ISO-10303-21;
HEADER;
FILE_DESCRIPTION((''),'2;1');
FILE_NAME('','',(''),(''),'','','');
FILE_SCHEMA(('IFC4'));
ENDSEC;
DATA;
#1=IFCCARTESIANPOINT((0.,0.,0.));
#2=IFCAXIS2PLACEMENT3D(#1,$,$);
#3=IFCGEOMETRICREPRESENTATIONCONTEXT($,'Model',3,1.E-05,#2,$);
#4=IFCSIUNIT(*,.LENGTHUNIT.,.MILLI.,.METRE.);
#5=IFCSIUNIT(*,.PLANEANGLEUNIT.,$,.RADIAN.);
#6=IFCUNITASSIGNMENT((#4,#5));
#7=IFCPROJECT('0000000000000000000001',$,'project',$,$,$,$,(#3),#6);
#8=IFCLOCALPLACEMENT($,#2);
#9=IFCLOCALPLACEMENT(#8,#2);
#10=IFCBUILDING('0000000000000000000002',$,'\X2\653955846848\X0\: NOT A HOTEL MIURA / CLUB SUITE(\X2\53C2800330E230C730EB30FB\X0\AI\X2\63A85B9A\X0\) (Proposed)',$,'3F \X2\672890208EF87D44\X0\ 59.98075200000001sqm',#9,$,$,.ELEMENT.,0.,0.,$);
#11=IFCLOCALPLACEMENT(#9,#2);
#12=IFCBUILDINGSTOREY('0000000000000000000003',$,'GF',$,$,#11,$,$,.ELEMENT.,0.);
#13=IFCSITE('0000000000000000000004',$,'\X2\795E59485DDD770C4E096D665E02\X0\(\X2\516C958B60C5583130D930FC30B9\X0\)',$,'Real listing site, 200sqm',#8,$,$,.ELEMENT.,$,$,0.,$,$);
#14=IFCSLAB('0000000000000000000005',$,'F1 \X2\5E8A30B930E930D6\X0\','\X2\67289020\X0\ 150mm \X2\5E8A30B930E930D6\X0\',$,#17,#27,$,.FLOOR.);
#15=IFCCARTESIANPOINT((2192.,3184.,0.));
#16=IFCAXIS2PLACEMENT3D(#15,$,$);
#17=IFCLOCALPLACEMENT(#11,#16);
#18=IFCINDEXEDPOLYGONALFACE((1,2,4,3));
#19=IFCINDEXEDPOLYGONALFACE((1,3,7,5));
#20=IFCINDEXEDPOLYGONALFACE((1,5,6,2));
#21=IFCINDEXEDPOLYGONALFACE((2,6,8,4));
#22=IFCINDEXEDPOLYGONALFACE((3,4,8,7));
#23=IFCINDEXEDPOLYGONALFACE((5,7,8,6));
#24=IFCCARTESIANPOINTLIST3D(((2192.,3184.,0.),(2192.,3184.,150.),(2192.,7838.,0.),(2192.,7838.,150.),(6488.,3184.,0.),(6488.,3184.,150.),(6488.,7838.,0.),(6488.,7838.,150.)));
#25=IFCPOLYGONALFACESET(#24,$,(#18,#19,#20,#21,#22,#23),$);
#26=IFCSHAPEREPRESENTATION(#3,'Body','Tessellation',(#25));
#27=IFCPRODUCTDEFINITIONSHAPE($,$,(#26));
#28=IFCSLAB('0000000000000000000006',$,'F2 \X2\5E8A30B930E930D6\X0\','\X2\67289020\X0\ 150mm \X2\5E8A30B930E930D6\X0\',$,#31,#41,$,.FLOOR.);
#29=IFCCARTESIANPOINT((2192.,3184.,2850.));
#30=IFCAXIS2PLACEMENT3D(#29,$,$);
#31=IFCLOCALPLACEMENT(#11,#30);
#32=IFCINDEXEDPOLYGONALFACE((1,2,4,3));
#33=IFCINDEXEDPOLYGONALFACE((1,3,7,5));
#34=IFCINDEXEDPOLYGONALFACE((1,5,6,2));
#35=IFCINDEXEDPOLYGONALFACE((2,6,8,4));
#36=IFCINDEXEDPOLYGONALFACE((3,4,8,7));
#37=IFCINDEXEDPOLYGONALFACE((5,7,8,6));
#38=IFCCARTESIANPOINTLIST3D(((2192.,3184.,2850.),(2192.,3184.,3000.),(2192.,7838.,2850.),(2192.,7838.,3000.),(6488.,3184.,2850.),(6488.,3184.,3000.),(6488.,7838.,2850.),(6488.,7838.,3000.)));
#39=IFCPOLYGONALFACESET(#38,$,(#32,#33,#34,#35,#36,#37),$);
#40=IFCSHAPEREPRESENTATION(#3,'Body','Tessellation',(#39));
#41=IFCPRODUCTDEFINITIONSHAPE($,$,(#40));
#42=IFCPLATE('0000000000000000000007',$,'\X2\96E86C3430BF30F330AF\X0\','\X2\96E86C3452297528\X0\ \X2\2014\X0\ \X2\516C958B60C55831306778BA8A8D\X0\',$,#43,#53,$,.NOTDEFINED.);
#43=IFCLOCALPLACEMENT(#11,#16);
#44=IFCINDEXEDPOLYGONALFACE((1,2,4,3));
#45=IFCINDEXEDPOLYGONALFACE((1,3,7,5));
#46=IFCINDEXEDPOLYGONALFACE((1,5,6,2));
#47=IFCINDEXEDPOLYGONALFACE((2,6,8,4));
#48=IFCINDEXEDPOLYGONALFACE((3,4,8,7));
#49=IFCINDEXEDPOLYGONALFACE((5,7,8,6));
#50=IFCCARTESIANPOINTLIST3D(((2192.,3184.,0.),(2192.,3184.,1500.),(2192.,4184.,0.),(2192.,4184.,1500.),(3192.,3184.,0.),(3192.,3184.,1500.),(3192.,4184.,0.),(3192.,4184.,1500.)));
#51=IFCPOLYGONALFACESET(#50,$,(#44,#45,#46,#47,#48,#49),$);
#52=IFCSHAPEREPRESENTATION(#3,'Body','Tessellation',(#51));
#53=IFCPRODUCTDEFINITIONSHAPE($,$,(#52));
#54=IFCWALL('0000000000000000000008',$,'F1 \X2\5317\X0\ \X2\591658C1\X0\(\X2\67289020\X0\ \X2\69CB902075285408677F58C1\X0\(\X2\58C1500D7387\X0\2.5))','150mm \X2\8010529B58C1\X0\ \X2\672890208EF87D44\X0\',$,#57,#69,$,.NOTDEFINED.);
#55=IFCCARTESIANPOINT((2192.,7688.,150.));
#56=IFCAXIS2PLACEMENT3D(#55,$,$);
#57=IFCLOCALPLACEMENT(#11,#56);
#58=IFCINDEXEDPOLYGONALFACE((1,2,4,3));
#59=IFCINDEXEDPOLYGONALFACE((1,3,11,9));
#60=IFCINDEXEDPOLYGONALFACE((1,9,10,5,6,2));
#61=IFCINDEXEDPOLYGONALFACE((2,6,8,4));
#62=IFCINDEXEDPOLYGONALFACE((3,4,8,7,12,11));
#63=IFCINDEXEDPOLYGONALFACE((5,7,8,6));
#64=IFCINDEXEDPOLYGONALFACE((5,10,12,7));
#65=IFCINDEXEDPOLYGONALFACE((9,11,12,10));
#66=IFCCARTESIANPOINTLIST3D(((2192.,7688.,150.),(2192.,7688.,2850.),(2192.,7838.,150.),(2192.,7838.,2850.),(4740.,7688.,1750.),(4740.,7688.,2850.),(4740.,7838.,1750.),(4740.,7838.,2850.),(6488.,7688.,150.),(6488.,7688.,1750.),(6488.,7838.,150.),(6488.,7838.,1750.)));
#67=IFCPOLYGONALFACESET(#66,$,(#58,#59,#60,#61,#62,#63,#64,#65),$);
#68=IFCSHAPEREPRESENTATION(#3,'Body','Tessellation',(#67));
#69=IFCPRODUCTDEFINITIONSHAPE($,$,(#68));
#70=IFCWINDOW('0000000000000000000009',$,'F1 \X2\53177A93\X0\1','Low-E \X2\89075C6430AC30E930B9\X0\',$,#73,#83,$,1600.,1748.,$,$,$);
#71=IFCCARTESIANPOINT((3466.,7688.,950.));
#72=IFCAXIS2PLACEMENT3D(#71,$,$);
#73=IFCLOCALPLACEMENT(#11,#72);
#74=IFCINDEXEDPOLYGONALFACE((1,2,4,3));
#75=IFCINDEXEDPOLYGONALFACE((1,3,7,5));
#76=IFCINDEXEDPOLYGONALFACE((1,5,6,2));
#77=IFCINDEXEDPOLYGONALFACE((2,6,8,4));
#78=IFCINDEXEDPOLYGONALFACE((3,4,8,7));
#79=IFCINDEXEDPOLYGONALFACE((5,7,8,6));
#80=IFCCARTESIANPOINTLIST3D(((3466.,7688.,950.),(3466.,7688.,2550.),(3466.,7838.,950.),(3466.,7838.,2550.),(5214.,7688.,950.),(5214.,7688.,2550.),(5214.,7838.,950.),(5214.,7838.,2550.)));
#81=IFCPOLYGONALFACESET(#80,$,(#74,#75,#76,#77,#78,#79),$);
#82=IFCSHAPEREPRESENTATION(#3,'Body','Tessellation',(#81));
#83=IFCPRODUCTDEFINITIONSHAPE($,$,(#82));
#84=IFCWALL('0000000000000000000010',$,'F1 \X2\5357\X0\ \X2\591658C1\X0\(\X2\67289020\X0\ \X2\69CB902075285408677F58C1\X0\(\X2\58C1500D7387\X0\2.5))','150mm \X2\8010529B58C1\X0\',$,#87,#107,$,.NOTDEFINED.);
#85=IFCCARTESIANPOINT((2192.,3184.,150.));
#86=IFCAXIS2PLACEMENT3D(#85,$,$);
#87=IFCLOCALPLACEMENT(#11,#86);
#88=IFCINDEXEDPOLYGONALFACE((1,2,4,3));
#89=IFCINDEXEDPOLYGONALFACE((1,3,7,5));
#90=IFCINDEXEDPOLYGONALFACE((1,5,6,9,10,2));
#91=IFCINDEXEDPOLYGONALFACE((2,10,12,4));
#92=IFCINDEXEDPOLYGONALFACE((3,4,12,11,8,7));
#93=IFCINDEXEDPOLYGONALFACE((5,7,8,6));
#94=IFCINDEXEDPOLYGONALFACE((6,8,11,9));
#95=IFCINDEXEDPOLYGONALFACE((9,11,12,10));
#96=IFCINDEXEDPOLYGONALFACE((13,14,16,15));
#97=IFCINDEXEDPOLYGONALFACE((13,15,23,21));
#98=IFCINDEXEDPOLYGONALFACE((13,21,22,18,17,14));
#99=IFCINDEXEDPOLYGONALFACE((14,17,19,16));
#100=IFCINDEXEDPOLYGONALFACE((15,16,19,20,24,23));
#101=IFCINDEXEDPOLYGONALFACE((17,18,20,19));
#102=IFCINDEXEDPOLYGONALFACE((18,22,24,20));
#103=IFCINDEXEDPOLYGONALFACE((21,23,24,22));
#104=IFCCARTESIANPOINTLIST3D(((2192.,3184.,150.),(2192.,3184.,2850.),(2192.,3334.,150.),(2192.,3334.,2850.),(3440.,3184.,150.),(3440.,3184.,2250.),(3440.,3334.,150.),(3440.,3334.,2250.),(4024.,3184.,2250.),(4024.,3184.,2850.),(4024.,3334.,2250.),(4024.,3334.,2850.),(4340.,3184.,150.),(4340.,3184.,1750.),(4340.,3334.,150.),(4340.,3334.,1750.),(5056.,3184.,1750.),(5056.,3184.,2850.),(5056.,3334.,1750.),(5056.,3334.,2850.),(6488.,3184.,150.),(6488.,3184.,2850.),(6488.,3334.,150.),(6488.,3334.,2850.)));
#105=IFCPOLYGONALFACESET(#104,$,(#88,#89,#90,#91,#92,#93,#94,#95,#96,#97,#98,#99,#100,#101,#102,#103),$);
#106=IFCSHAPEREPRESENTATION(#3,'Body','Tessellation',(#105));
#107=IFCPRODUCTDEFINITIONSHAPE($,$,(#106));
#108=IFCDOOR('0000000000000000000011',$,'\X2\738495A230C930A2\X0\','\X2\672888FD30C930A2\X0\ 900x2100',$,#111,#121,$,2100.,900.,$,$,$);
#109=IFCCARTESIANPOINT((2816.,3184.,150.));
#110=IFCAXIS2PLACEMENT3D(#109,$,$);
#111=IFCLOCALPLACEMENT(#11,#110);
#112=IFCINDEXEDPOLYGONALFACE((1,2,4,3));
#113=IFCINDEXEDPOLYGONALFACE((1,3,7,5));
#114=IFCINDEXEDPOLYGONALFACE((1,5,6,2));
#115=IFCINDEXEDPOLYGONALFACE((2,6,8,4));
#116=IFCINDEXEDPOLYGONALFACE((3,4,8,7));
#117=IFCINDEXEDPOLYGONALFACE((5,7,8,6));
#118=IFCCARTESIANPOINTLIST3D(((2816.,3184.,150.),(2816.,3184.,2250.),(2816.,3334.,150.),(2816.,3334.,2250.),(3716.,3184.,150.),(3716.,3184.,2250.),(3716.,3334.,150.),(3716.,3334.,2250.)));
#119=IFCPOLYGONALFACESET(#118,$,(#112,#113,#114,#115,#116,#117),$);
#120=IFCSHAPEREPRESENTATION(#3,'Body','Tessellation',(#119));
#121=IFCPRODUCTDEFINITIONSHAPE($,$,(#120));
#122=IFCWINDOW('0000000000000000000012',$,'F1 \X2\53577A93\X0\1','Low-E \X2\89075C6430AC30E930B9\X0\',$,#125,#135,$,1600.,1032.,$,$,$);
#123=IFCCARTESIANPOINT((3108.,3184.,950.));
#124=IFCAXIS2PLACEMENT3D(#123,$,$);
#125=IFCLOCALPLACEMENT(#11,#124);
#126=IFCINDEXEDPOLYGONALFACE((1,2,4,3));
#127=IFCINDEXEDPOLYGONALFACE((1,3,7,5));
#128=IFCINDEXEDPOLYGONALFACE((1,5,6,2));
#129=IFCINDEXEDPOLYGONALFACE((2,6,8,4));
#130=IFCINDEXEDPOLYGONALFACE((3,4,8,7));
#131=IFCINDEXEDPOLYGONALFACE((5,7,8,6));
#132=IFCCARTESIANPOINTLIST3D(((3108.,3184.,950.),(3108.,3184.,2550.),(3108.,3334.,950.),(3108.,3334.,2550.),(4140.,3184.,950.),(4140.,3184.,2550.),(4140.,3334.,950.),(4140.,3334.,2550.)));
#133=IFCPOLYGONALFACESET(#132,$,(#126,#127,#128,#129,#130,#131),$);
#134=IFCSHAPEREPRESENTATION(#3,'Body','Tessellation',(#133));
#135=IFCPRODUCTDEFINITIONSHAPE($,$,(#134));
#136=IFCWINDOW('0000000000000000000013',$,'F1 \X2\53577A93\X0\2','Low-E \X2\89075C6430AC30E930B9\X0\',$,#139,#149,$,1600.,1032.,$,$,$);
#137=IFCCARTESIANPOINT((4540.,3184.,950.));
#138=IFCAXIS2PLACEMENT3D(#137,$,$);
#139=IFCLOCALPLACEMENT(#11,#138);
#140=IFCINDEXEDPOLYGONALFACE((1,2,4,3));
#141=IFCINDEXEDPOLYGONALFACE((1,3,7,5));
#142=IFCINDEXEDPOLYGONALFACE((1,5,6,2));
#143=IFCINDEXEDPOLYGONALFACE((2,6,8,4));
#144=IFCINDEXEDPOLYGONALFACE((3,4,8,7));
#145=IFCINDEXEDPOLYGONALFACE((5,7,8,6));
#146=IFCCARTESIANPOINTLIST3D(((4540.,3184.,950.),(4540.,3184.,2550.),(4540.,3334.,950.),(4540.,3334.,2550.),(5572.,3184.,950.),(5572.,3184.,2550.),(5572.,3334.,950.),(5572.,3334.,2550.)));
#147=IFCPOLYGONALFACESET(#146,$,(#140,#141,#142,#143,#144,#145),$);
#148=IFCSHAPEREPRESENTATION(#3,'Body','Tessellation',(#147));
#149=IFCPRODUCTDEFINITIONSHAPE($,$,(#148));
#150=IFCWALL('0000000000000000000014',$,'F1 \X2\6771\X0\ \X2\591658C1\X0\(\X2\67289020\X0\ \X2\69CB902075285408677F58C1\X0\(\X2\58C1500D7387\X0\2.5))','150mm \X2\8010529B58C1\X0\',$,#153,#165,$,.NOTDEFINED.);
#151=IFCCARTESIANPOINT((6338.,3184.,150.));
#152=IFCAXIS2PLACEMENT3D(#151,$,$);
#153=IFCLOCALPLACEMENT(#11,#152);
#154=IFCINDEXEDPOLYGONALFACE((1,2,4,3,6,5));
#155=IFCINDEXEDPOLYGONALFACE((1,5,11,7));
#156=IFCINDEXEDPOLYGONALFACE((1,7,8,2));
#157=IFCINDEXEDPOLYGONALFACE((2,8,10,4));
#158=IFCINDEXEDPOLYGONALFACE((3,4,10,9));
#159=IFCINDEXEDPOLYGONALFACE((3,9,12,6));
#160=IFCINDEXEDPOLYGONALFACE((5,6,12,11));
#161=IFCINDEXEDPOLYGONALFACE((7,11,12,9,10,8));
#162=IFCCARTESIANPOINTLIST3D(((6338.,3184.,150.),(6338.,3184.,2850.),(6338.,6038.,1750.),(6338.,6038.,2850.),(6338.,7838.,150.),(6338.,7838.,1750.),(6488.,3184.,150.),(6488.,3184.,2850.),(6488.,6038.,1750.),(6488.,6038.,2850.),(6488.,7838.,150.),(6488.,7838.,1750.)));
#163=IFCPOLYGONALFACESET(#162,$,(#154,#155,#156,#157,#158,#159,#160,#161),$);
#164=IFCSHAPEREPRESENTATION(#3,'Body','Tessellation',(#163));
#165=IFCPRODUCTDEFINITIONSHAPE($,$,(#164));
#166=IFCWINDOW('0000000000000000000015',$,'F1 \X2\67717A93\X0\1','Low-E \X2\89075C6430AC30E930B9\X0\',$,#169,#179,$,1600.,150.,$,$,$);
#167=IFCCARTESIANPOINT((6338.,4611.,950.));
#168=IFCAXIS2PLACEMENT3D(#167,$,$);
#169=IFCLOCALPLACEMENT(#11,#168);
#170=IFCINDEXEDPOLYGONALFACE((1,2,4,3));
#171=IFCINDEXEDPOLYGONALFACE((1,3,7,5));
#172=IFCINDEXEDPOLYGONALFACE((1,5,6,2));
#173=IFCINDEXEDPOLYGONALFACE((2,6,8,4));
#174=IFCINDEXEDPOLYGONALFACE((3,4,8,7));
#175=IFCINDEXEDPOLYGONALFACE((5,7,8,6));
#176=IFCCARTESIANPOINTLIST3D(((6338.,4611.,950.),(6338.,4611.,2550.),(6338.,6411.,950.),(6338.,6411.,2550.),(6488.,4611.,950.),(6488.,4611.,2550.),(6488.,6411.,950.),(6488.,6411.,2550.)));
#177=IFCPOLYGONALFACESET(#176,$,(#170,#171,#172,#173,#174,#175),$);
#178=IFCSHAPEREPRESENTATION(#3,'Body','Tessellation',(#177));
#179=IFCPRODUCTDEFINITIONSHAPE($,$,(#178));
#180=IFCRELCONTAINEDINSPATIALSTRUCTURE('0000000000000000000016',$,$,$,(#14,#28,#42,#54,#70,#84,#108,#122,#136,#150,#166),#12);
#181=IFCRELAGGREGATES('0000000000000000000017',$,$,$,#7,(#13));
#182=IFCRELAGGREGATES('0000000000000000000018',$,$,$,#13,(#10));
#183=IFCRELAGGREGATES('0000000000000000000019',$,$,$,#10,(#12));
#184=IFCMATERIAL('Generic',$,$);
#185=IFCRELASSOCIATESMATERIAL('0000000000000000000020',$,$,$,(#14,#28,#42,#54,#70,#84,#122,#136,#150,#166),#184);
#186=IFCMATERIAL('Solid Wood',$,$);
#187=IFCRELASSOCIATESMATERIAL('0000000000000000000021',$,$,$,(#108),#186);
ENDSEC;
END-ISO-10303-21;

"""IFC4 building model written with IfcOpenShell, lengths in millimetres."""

from ifc_helpers import new_model, si_unit, frame, frame_2d, origin, place, context, project, spatial, rectangle, extrude, material, element, fill, save


model = new_model("IFC4")

# Units and contexts
model_context = context("Model", 3, precision=1e-05, world=origin())
ifc_project = project(units=[si_unit("LENGTHUNIT", "METRE", prefix="MILLI"), si_unit("PLANEANGLEUNIT", "RADIAN")], contexts=[model_context])

# Site, building, storey
site_placement = place(None, origin())
site = spatial("IfcSite", under=ifc_project, at=site_placement, Name="神奈川県三浦市(公開情報ベース)", ObjectType="Real listing site, 200sqm", CompositionType="ELEMENT", RefElevation=0.0)
building_placement = place(site_placement, origin())
building = spatial("IfcBuilding", under=site, at=building_placement, Name="改善案: NOT A HOTEL MIURA / CLUB SUITE(参考モデル・AI推定) (Proposed)", ObjectType="3F 木造軸組 59.98075200000001sqm", CompositionType="ELEMENT", ElevationOfRefHeight=0.0, ElevationOfTerrain=0.0)
storey_placement = place(building_placement, origin())
storey = spatial("IfcBuildingStorey", under=building, at=storey_placement, Name="GF", CompositionType="ELEMENT", Elevation=0.0)

# Slabs
ifc_material_1 = material(Name="Generic")
slab_1_placement = place(storey_placement, frame((2192.0, 3184.0, 0.0)))
element("IfcSlab", 1, at=slab_1_placement, inside=storey, material=ifc_material_1, Name="F1 床スラブ", Description="木造 150mm 床スラブ", PredefinedType="FLOOR", context=model_context, shape_type="SweptSolid", body=[
    extrude(rectangle(XDim=4296.0, YDim=4654.0, at=frame_2d((2148.0, 2327.0))), frame((2192.0, 3184.0, 0.0)), (0.0, 0.0, 1.0), 150.0),
])
slab_2_placement = place(storey_placement, frame((2192.0, 3184.0, 2850.0)))
element("IfcSlab", 2, at=slab_2_placement, inside=storey, material=ifc_material_1, Name="F2 床スラブ", Description="木造 150mm 床スラブ", PredefinedType="FLOOR", context=model_context, shape_type="SweptSolid", body=[
    extrude(rectangle(XDim=4296.0, YDim=4654.0, at=frame_2d((2148.0, 2327.0))), frame((2192.0, 3184.0, 2850.0)), (0.0, 0.0, 1.0), 150.0),
])

# Plate
plate_placement = place(storey_placement, frame((2192.0, 3184.0, 0.0)))
element("IfcPlate", 3, at=plate_placement, inside=storey, material=ifc_material_1, Name="雨水タンク", Description="雨水利用 — 公開情報で確認", PredefinedType="NOTDEFINED", context=model_context, shape_type="SweptSolid", body=[
    extrude(rectangle(XDim=1000.0, YDim=1000.0, at=frame_2d((500.0, 500.0))), frame((2192.0, 3184.0, 0.0)), (0.0, 0.0, 1.0), 1500.0),
])

# Wall, opening, window
wall_1_placement = place(storey_placement, frame((2192.0, 7688.0, 150.0)))
wall_1 = element("IfcWall", 4, at=wall_1_placement, inside=storey, material=ifc_material_1, Name="F1 北 外壁(木造 構造用合板壁(壁倍率2.5))", Description="150mm 耐力壁 木造軸組", PredefinedType="NOTDEFINED", context=model_context, shape_type="SweptSolid", body=[
    extrude(rectangle(XDim=4296.0, YDim=150.0, at=frame_2d((2148.0, 75.0))), frame((2192.0, 7688.0, 150.0)), (0.0, 0.0, 1.0), 2700.0),
])
opening_1_placement = place(storey_placement, frame((3466.0, 7688.0, 950.0)))
opening_1 = element("IfcOpeningElement", 5, at=opening_1_placement, cuts=wall_1, PredefinedType="NOTDEFINED", context=model_context, shape_type="SweptSolid", body=[
    extrude(rectangle(XDim=1748.0, YDim=150.0, at=frame_2d((874.0, 75.0))), frame((3466.0, 7688.0, 950.0)), (0.0, 0.0, 1.0), 1600.0),
])
window_1_placement = place(storey_placement, frame((3466.0, 7688.0, 950.0)))
window_1 = element("IfcWindow", 6, at=window_1_placement, inside=storey, material=ifc_material_1, Name="F1 北窓1", Description="Low-E 複層ガラス", OverallHeight=1600.0, OverallWidth=1748.0, context=model_context, shape_type="SweptSolid", body=[
    extrude(rectangle(XDim=1748.0, YDim=150.0, at=frame_2d((874.0, 75.0))), frame((3466.0, 7688.0, 950.0)), (0.0, 0.0, 1.0), 1600.0),
])
fill(opening_1, window_1)

# Wall, openings, door, windows
wall_2_placement = place(storey_placement, frame((2192.0, 3184.0, 150.0)))
wall_2 = element("IfcWall", 7, at=wall_2_placement, inside=storey, material=ifc_material_1, Name="F1 南 外壁(木造 構造用合板壁(壁倍率2.5))", Description="150mm 耐力壁", PredefinedType="NOTDEFINED", context=model_context, shape_type="SweptSolid", body=[
    extrude(rectangle(XDim=4296.0, YDim=150.0, at=frame_2d((2148.0, 75.0))), frame((2192.0, 3184.0, 150.0)), (0.0, 0.0, 1.0), 2700.0),
])
opening_2_placement = place(storey_placement, frame((2816.0, 3184.0, 150.0)))
opening_2 = element("IfcOpeningElement", 8, at=opening_2_placement, cuts=wall_2, PredefinedType="NOTDEFINED", context=model_context, shape_type="SweptSolid", body=[
    extrude(rectangle(XDim=900.0, YDim=150.0, at=frame_2d((450.0, 75.0))), frame((2816.0, 3184.0, 150.0)), (0.0, 0.0, 1.0), 2100.0),
])
opening_3_placement = place(storey_placement, frame((3108.0, 3184.0, 950.0)))
opening_3 = element("IfcOpeningElement", 9, at=opening_3_placement, cuts=wall_2, PredefinedType="NOTDEFINED", context=model_context, shape_type="SweptSolid", body=[
    extrude(rectangle(XDim=1032.0, YDim=150.0, at=frame_2d((516.0, 75.0))), frame((3108.0, 3184.0, 950.0)), (0.0, 0.0, 1.0), 1600.0),
])
opening_4_placement = place(storey_placement, frame((4540.0, 3184.0, 950.0)))
opening_4 = element("IfcOpeningElement", 10, at=opening_4_placement, cuts=wall_2, PredefinedType="NOTDEFINED", context=model_context, shape_type="SweptSolid", body=[
    extrude(rectangle(XDim=1032.0, YDim=150.0, at=frame_2d((516.0, 75.0))), frame((4540.0, 3184.0, 950.0)), (0.0, 0.0, 1.0), 1600.0),
])
ifc_material_2 = material(Name="Solid Wood")
door_placement = place(storey_placement, frame((2816.0, 3184.0, 150.0)))
door = element("IfcDoor", 11, at=door_placement, inside=storey, material=ifc_material_2, Name="玄関ドア", Description="木製ドア 900x2100", OverallHeight=2100.0, OverallWidth=900.0, context=model_context, shape_type="SweptSolid", body=[
    extrude(rectangle(XDim=900.0, YDim=150.0, at=frame_2d((450.0, 75.0))), frame((2816.0, 3184.0, 150.0)), (0.0, 0.0, 1.0), 2100.0),
])
fill(opening_2, door)
window_2_placement = place(storey_placement, frame((3108.0, 3184.0, 950.0)))
window_2 = element("IfcWindow", 12, at=window_2_placement, inside=storey, material=ifc_material_1, Name="F1 南窓1", Description="Low-E 複層ガラス", OverallHeight=1600.0, OverallWidth=1032.0, context=model_context, shape_type="SweptSolid", body=[
    extrude(rectangle(XDim=1032.0, YDim=150.0, at=frame_2d((516.0, 75.0))), frame((3108.0, 3184.0, 950.0)), (0.0, 0.0, 1.0), 1600.0),
])
fill(opening_3, window_2)
window_3_placement = place(storey_placement, frame((4540.0, 3184.0, 950.0)))
window_3 = element("IfcWindow", 13, at=window_3_placement, inside=storey, material=ifc_material_1, Name="F1 南窓2", Description="Low-E 複層ガラス", OverallHeight=1600.0, OverallWidth=1032.0, context=model_context, shape_type="SweptSolid", body=[
    extrude(rectangle(XDim=1032.0, YDim=150.0, at=frame_2d((516.0, 75.0))), frame((4540.0, 3184.0, 950.0)), (0.0, 0.0, 1.0), 1600.0),
])
fill(opening_4, window_3)

# Wall, opening, window
wall_3_placement = place(storey_placement, frame((6338.0, 3184.0, 150.0)))
wall_3 = element("IfcWall", 14, at=wall_3_placement, inside=storey, material=ifc_material_1, Name="F1 東 外壁(木造 構造用合板壁(壁倍率2.5))", Description="150mm 耐力壁", PredefinedType="NOTDEFINED", context=model_context, shape_type="SweptSolid", body=[
    extrude(rectangle(XDim=150.0, YDim=4654.0, at=frame_2d((75.0, 2327.0))), frame((6338.0, 3184.0, 150.0)), (0.0, 0.0, 1.0), 2700.0),
])
opening_5_placement = place(storey_placement, frame((6338.0, 4611.0, 950.0)))
opening_5 = element("IfcOpeningElement", 15, at=opening_5_placement, cuts=wall_3, PredefinedType="NOTDEFINED", context=model_context, shape_type="SweptSolid", body=[
    extrude(rectangle(XDim=150.0, YDim=1800.0, at=frame_2d((75.0, 900.0))), frame((6338.0, 4611.0, 950.0)), (0.0, 0.0, 1.0), 1600.0),
])
window_4_placement = place(storey_placement, frame((6338.0, 4611.0, 950.0)))
window_4 = element("IfcWindow", 16, at=window_4_placement, inside=storey, material=ifc_material_1, Name="F1 東窓1", Description="Low-E 複層ガラス", OverallHeight=1600.0, OverallWidth=150.0, context=model_context, shape_type="SweptSolid", body=[
    extrude(rectangle(XDim=150.0, YDim=1800.0, at=frame_2d((75.0, 900.0))), frame((6338.0, 4611.0, 950.0)), (0.0, 0.0, 1.0), 1600.0),
])
fill(opening_5, window_4)

save(model, "model.ifc")
